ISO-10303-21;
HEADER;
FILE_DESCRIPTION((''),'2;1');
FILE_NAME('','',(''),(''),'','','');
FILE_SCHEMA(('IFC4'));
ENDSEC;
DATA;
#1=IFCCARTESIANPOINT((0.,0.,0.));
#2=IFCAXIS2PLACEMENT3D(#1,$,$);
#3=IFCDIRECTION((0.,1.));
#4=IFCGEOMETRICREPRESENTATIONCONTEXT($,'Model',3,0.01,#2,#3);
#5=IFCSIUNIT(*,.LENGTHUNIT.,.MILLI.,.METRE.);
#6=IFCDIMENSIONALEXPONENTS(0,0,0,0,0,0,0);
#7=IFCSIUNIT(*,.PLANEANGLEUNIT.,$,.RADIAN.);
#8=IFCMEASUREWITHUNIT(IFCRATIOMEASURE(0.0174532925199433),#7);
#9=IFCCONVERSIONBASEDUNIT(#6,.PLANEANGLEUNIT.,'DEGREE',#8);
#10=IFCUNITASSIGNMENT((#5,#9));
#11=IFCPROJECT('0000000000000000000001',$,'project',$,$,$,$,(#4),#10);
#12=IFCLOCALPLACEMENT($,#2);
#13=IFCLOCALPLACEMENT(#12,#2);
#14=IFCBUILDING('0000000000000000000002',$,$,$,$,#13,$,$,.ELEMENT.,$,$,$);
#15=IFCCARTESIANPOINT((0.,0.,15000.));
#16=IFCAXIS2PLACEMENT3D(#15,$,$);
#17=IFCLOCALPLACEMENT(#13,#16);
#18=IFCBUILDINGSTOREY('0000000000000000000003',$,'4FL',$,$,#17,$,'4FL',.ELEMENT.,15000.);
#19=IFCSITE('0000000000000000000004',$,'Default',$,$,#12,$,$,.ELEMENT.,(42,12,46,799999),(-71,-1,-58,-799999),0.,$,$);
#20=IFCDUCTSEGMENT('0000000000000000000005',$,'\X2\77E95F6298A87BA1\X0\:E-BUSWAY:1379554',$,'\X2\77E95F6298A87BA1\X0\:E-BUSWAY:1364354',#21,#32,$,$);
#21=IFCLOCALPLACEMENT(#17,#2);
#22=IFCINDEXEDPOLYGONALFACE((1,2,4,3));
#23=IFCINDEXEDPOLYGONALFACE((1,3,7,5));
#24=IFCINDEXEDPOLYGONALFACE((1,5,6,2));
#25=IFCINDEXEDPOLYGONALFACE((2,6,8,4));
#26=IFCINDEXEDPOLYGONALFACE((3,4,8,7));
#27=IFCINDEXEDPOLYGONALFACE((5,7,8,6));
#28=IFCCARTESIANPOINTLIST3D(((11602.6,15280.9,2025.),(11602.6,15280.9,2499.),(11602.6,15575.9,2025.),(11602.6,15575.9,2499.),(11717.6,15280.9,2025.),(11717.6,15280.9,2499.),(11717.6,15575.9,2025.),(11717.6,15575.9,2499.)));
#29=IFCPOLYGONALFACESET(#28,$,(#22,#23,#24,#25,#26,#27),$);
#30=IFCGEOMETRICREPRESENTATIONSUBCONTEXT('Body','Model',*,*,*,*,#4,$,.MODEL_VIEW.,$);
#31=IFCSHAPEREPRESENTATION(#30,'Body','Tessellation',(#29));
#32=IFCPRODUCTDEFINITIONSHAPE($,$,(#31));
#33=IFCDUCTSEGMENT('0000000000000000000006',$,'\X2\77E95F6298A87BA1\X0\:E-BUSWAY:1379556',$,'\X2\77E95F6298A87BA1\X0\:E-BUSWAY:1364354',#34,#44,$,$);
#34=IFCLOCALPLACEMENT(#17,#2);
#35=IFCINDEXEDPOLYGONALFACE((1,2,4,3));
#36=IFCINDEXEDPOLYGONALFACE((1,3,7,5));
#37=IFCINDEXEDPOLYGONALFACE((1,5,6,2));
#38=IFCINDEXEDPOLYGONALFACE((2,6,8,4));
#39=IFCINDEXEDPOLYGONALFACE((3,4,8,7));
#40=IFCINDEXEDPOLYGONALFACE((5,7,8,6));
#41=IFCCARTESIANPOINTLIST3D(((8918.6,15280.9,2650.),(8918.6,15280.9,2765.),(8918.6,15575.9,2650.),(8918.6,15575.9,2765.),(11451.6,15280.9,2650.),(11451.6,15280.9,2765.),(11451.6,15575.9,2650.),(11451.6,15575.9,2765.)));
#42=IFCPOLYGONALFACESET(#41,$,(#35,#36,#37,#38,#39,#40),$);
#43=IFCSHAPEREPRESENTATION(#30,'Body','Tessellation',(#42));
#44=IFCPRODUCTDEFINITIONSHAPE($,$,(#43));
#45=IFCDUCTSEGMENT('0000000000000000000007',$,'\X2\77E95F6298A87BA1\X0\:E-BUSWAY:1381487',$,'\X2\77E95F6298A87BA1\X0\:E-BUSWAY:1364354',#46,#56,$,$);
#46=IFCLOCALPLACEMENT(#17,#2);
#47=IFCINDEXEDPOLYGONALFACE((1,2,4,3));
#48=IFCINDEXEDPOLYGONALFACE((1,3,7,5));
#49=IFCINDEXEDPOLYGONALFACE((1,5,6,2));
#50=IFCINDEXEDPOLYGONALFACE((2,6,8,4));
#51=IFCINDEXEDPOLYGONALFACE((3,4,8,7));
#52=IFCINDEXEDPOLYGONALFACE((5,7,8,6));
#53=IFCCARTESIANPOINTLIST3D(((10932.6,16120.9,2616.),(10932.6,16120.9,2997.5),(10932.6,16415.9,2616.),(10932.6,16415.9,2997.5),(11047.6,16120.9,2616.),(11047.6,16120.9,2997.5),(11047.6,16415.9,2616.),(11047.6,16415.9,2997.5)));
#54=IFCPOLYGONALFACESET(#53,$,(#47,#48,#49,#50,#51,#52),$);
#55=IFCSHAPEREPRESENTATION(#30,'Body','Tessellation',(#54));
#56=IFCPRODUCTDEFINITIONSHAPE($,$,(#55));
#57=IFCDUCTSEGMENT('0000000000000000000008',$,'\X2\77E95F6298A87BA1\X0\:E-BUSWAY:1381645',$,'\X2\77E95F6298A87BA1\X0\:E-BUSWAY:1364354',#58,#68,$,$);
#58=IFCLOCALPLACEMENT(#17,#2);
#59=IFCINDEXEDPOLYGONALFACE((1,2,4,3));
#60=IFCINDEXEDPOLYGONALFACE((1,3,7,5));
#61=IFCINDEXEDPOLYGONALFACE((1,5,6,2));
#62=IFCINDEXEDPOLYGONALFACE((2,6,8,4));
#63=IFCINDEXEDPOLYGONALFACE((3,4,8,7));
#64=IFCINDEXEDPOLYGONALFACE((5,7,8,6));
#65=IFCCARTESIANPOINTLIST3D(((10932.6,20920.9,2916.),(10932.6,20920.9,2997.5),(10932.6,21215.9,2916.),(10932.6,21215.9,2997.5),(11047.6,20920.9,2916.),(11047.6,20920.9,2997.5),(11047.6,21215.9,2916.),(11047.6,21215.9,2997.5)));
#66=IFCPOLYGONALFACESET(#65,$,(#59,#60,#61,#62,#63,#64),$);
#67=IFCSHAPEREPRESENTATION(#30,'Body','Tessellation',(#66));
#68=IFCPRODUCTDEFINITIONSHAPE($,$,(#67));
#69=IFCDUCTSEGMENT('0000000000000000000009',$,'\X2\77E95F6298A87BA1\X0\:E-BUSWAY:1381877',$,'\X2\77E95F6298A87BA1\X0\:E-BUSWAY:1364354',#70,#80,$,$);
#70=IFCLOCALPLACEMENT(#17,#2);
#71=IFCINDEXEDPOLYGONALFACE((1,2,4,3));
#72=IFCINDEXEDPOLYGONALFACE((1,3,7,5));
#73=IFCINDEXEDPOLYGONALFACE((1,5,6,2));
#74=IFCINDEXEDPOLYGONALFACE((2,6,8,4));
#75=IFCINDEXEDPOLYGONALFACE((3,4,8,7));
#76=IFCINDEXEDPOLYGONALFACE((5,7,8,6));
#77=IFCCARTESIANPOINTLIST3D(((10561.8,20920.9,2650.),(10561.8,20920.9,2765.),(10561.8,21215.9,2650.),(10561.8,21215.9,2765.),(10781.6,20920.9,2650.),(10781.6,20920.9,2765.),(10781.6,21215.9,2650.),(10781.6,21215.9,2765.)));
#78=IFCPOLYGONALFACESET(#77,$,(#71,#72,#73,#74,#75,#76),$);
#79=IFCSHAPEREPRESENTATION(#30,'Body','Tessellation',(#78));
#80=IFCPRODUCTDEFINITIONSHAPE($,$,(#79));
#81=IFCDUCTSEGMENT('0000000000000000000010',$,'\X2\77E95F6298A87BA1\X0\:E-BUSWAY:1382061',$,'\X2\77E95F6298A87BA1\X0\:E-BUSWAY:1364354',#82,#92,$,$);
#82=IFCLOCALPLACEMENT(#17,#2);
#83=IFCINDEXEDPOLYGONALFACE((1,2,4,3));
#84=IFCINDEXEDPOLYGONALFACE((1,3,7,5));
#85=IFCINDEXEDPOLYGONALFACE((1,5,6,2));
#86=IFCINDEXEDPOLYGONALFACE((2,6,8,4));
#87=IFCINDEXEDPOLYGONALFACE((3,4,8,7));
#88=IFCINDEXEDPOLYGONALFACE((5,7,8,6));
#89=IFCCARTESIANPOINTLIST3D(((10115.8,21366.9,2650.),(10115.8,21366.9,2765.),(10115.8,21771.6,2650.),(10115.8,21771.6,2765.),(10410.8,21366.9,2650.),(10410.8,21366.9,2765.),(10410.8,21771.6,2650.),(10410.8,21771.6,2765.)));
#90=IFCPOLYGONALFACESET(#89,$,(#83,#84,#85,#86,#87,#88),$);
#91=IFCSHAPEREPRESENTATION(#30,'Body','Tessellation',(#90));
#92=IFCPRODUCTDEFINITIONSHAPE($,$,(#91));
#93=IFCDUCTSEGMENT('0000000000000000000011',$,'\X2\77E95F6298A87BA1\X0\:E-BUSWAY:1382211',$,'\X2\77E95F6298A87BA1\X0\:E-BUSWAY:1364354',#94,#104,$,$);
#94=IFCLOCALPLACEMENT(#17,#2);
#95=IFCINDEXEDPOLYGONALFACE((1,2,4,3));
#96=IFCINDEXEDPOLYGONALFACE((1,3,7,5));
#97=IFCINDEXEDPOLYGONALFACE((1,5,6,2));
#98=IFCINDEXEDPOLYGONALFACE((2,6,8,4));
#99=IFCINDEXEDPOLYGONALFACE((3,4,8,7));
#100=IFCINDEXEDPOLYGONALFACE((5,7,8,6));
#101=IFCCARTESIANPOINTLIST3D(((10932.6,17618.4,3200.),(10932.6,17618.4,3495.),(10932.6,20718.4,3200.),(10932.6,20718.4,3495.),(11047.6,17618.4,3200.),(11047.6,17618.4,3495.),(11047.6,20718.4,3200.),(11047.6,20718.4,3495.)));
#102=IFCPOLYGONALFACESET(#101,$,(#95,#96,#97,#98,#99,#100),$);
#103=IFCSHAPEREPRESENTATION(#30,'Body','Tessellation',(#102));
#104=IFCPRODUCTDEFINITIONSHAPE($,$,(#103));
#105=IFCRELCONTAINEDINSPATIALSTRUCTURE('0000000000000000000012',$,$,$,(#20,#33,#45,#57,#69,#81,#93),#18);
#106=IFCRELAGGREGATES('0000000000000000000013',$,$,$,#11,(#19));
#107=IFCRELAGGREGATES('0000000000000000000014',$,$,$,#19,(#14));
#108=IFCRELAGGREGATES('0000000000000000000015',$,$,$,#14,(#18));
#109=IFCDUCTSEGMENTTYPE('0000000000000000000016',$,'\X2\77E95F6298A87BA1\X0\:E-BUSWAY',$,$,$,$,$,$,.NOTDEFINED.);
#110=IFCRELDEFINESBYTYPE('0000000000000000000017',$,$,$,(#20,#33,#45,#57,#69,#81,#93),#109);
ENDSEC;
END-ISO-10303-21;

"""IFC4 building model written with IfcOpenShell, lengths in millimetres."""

from ifc_helpers import new_model, entity, si_unit, converted_unit, direction, frame, frame_2d, origin, origin_2d_with_axis, place, context, subcontext, project, spatial, rectangle, extrude, type_object, element, save


model = new_model("IFC4")

# Units and contexts
model_context = context("Model", 3, precision=0.01, world=origin(), true_north=direction((0.0, 1.0)))
body_context = subcontext(model_context, "Body", "Model", "MODEL_VIEW")
ifc_project = project(units=[si_unit("LENGTHUNIT", "METRE", prefix="MILLI"), converted_unit("PLANEANGLEUNIT", "DEGREE", entity("IfcRatioMeasure", 0.0174532925199433), si_unit("PLANEANGLEUNIT", "RADIAN"), dimensions=[0, 0, 0, 0, 0, 0, 0])], contexts=[model_context])

# Site, building, storey
site_placement = place(None, origin())
site = spatial("IfcSite", under=ifc_project, at=site_placement, Name="Default", CompositionType="ELEMENT", RefLatitude=(42, 12, 46, 799999), RefLongitude=(-71, -1, -58, -799999), RefElevation=0.0)
building_placement = place(site_placement, origin())
building = spatial("IfcBuilding", under=site, at=building_placement, CompositionType="ELEMENT")
storey_placement = place(building_placement, frame((0.0, 0.0, 15000.0)))
storey = spatial("IfcBuildingStorey", under=building, at=storey_placement, Name="4FL", LongName="4FL", CompositionType="ELEMENT", Elevation=15000.0)

# Duct segments
duct_segment_type = type_object("IfcDuctSegmentType", Name="矩形風管:E-BUSWAY", PredefinedType="NOTDEFINED")
duct_segment_1_placement = place(storey_placement, frame((11602.6, 15280.9, 2025.0)))
element("IfcDuctSegment", 1, at=duct_segment_1_placement, inside=storey, type_object=duct_segment_type, Name="矩形風管:E-BUSWAY:1379554", ObjectType="矩形風管:E-BUSWAY:1364354", context=body_context, shape_type="SweptSolid", body=[
    extrude(rectangle(XDim=115.0, YDim=295.0, at=frame_2d((0.0, 0.0), x_axis=(1.0, 0.0))), frame((57.5, 147.5, 0.0), z_axis=(0.0, 0.0, 1.0), x_axis=(-1.0, 0.0, 0.0)), (0.0, 0.0, 1.0), 474.0),
])
duct_segment_2_placement = place(storey_placement, frame((8918.6, 15280.9, 2650.0)))
element("IfcDuctSegment", 2, at=duct_segment_2_placement, inside=storey, type_object=duct_segment_type, Name="矩形風管:E-BUSWAY:1379556", ObjectType="矩形風管:E-BUSWAY:1364354", context=body_context, shape_type="SweptSolid", body=[
    extrude(rectangle(XDim=2533.0, YDim=295.0, at=origin_2d_with_axis()), frame((1266.5, 147.5, 0.0)), (0.0, 0.0, 1.0), 115.0),
])
duct_segment_3_placement = place(storey_placement, frame((10932.6, 16120.9, 2616.0)))
element("IfcDuctSegment", 3, at=duct_segment_3_placement, inside=storey, type_object=duct_segment_type, Name="矩形風管:E-BUSWAY:1381487", ObjectType="矩形風管:E-BUSWAY:1364354", context=body_context, shape_type="SweptSolid", body=[
    extrude(rectangle(XDim=295.0, YDim=115.0, at=origin_2d_with_axis()), frame((57.5, 147.5, 0.0), z_axis=(0.0, 0.0, 1.0), x_axis=(0.0, -1.0, 0.0)), (0.0, 0.0, 1.0), 381.5),
])
duct_segment_4_placement = place(storey_placement, frame((10932.6, 20920.9, 2916.0)))
element("IfcDuctSegment", 4, at=duct_segment_4_placement, inside=storey, type_object=duct_segment_type, Name="矩形風管:E-BUSWAY:1381645", ObjectType="矩形風管:E-BUSWAY:1364354", context=body_context, shape_type="SweptSolid", body=[
    extrude(rectangle(XDim=115.0, YDim=295.0, at=origin_2d_with_axis()), frame((57.5, 147.5, 0.0)), (0.0, 0.0, 1.0), 81.5),
])
duct_segment_5_placement = place(storey_placement, frame((10561.8, 20920.9, 2650.0)))
element("IfcDuctSegment", 5, at=duct_segment_5_placement, inside=storey, type_object=duct_segment_type, Name="矩形風管:E-BUSWAY:1381877", ObjectType="矩形風管:E-BUSWAY:1364354", context=body_context, shape_type="SweptSolid", body=[
    extrude(rectangle(XDim=219.8, YDim=295.0, at=frame_2d((0.0, 0.0), x_axis=(1.0, 0.0))), frame((109.9, 147.5, 0.0), z_axis=(0.0, 0.0, 1.0), x_axis=(-1.0, 0.0, 0.0)), (0.0, 0.0, 1.0), 115.0),
])
duct_segment_6_placement = place(storey_placement, frame((10115.8, 21366.9, 2650.0)))
element("IfcDuctSegment", 6, at=duct_segment_6_placement, inside=storey, type_object=duct_segment_type, Name="矩形風管:E-BUSWAY:1382061", ObjectType="矩形風管:E-BUSWAY:1364354", context=body_context, shape_type="SweptSolid", body=[
    extrude(rectangle(XDim=404.7, YDim=295.0, at=frame_2d((0.0, 0.0), x_axis=(1.0, 0.0))), frame((147.5, 202.3, 0.0), z_axis=(0.0, 0.0, 1.0), x_axis=(0.0, 1.0, 0.0)), (0.0, 0.0, 1.0), 115.0),
])
duct_segment_7_placement = place(storey_placement, frame((10932.6, 17618.4, 3200.0)))
element("IfcDuctSegment", 7, at=duct_segment_7_placement, inside=storey, type_object=duct_segment_type, Name="矩形風管:E-BUSWAY:1382211", ObjectType="矩形風管:E-BUSWAY:1364354", context=body_context, shape_type="SweptSolid", body=[
    extrude(rectangle(XDim=3100.0, YDim=115.0, at=frame_2d((0.0, 0.0), x_axis=(1.0, 0.0))), frame((57.5, 1550.0, 0.0), z_axis=(0.0, 0.0, 1.0), x_axis=(0.0, 1.0, 0.0)), (0.0, 0.0, 1.0), 295.0),
])

save(model, "model.ifc")
